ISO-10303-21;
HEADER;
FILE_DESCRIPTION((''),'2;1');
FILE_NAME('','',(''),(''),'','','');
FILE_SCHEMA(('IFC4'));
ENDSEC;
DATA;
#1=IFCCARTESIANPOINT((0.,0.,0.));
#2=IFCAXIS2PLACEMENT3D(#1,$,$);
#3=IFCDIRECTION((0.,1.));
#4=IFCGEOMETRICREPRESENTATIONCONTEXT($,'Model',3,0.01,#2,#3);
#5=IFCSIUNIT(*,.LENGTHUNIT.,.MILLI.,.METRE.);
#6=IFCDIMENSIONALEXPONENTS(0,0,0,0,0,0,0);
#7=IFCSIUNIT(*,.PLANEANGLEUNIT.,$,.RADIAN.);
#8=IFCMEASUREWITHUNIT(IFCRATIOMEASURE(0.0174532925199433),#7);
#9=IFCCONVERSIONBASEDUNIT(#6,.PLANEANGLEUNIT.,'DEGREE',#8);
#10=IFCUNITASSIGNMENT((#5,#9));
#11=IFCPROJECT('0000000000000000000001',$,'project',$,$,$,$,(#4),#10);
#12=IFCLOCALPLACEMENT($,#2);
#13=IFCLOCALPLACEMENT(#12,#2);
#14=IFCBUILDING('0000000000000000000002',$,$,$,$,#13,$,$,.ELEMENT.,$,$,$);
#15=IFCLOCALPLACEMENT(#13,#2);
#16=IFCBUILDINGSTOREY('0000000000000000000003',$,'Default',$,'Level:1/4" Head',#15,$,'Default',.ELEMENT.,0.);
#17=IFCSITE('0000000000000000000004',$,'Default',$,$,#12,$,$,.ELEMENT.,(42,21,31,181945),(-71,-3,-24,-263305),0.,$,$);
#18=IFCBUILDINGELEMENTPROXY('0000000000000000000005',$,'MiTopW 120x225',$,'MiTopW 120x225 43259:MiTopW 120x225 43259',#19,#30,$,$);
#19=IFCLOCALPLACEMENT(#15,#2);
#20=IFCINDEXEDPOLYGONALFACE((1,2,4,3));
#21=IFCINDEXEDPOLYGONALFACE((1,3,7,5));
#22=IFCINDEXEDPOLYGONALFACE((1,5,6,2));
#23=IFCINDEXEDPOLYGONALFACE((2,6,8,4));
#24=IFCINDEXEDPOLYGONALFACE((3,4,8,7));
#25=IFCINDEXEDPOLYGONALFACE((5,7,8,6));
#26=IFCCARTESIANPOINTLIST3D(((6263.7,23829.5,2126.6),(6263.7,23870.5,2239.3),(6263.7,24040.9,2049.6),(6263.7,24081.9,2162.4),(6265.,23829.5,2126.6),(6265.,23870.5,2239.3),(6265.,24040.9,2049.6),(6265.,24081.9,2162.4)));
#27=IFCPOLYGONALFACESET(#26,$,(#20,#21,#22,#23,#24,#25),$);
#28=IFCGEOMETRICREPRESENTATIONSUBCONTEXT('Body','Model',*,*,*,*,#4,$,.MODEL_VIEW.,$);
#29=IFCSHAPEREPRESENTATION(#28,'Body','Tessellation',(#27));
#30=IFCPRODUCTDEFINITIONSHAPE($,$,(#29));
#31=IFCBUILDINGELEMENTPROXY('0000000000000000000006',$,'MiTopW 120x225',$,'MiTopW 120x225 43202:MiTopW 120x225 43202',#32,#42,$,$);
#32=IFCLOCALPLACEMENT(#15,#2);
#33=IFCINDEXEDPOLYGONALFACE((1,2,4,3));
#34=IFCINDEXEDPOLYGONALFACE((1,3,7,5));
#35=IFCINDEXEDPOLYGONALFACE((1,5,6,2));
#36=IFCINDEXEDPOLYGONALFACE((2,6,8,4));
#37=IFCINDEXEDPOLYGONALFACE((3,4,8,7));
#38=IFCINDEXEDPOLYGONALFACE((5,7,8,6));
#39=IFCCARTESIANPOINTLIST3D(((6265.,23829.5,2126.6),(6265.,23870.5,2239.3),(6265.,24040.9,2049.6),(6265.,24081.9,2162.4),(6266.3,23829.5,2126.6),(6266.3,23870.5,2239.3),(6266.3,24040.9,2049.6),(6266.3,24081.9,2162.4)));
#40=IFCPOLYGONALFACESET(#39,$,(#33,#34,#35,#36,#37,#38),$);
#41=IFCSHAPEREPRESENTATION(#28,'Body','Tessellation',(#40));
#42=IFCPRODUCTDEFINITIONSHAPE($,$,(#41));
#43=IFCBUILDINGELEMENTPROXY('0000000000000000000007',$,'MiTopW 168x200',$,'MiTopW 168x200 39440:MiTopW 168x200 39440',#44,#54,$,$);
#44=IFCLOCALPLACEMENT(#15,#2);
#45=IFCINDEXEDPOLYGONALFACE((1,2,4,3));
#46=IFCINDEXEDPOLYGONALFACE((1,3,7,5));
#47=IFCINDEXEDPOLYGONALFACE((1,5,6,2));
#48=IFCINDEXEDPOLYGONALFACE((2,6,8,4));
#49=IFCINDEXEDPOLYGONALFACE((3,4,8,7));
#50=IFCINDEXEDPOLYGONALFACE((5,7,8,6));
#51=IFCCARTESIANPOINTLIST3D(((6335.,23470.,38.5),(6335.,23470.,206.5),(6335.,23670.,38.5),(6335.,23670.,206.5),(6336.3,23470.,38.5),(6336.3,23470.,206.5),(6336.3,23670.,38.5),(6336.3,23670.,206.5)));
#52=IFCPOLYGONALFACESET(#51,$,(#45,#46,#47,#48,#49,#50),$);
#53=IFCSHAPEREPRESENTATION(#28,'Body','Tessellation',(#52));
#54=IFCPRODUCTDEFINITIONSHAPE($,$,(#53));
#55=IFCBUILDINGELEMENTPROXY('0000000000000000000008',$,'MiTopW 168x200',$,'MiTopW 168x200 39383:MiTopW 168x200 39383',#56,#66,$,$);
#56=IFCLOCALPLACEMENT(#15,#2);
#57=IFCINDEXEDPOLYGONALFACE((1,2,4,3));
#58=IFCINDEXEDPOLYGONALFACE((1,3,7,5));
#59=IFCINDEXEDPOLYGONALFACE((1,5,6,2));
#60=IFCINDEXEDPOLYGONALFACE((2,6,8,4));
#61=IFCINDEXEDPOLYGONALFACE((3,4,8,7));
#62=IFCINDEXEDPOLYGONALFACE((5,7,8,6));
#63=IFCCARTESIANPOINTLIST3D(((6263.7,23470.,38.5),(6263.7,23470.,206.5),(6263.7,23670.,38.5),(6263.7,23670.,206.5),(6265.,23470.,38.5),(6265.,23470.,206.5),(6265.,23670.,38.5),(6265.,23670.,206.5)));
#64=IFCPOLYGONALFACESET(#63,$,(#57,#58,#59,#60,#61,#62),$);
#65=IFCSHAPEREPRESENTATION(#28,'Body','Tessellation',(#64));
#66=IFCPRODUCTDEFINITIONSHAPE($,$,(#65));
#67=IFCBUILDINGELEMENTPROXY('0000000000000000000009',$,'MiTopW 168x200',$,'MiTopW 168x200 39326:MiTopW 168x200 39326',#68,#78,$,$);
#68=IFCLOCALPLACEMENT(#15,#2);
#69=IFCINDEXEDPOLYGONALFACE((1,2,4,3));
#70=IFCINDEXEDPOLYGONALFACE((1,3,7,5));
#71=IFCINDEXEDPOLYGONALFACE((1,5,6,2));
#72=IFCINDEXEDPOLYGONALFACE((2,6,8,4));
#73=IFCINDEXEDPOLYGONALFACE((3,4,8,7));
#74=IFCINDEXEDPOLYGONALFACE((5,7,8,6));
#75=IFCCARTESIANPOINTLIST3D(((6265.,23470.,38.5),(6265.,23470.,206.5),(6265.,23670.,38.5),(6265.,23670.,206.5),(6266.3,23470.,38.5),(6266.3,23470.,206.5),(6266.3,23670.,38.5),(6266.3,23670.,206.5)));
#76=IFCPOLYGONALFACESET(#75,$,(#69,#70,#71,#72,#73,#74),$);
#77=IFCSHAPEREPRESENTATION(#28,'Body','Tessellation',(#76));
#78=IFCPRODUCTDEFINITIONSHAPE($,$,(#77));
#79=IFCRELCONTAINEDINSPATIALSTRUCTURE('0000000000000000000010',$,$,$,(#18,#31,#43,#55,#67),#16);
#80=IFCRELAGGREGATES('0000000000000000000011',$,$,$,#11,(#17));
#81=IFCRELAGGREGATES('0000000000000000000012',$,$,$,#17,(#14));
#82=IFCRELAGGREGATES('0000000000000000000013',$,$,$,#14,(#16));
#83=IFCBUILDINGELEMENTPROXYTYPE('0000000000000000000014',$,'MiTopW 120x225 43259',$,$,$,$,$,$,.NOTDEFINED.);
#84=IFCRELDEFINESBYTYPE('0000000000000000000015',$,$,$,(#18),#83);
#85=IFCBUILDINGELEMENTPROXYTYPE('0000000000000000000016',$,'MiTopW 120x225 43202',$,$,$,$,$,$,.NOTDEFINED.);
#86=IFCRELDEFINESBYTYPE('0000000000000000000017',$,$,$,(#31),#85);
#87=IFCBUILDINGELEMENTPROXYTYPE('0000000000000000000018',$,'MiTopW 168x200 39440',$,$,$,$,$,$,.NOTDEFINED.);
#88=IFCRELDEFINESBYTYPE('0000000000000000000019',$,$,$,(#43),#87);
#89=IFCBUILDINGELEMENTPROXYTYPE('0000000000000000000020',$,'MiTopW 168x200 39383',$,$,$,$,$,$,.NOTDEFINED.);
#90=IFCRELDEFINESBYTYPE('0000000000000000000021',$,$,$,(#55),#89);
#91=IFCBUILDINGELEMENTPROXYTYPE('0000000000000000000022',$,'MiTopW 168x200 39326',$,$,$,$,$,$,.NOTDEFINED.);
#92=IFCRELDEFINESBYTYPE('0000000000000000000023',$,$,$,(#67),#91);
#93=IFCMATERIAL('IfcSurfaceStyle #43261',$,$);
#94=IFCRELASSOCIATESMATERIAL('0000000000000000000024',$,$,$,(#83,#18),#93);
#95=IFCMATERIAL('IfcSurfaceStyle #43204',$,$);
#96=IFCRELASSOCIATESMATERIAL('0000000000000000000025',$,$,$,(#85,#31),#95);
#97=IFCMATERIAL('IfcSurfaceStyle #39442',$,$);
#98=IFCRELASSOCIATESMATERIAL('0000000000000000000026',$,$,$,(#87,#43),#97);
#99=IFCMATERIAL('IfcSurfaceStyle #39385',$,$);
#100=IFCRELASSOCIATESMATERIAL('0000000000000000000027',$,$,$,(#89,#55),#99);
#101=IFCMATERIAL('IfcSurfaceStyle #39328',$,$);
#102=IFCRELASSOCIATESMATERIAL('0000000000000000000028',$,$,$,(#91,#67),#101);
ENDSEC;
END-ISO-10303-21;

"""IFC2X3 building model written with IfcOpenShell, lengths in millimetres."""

from ifc_helpers import new_model, entity, si_unit, converted_unit, direction, frame, origin, origin_2d_with_axis, place, context, subcontext, project, spatial, polyline, rectangle, outline, extrude, source, transform, mapped, material, type_object, type_shapes, element, save


model = new_model("IFC2X3")

# Units and contexts
model_context = context("Model", 3, precision=0.01, world=origin(), true_north=direction((0.0, 1.0)))
body_context = subcontext(model_context, "Body", "Model", "MODEL_VIEW")
ifc_project = project(units=[si_unit("LENGTHUNIT", "METRE", prefix="MILLI"), converted_unit("PLANEANGLEUNIT", "DEGREE", entity("IfcRatioMeasure", 0.0174532925199433), si_unit("PLANEANGLEUNIT", "RADIAN"), dimensions=[0, 0, 0, 0, 0, 0, 0])], contexts=[model_context])

# Site, building, storey
site_placement = place(None, origin())
site = spatial("IfcSite", under=ifc_project, at=site_placement, Name="Default", CompositionType="ELEMENT", RefLatitude=(42, 21, 31, 181945), RefLongitude=(-71, -3, -24, -263305), RefElevation=0.0)
building_placement = place(site_placement, origin())
building = spatial("IfcBuilding", under=site, at=building_placement, CompositionType="ELEMENT")
storey_placement = place(building_placement, origin())
storey = spatial("IfcBuildingStorey", under=building, at=storey_placement, Name="Default", ObjectType="Level:1/4\" Head", LongName="Default", CompositionType="ELEMENT", Elevation=0.0)

# Building element proxies
ifc_material_1 = material(Name="IfcSurfaceStyle #43261")
building_element_proxy_type_1 = type_object("IfcBuildingElementProxyType", Name="MiTopW 120x225 43259", PredefinedType="NOTDEFINED", material=ifc_material_1)
shared_shape_1 = source(origin(), body_context, "Body", "SweptSolid", [
    extrude(outline(polyline([(-112.5, -60.0), (112.5, -60.0), (112.5, 60.0), (-112.5, 60.0), (-112.5, -60.0)])), frame((112.5, 60.0, 0.0), z_axis=(0.0, 0.0, 1.0), x_axis=(-1.0, 0.0, 0.0)), (0.0, 0.0, 1.0), 1.3),
])
type_shapes(building_element_proxy_type_1, [shared_shape_1])
proxy_1_placement = place(building_placement, frame((6265.0, 24040.9, 2049.6), z_axis=(-1.0, 0.0, 0.0), x_axis=(0.0, -0.939693, 0.34202)))
element("IfcBuildingElementProxy", 1, at=proxy_1_placement, inside=storey, type_object=building_element_proxy_type_1, material=ifc_material_1, Name="MiTopW 120x225", ObjectType="MiTopW 120x225 43259:MiTopW 120x225 43259", context=body_context, shape_type="MappedRepresentation", body=[
    mapped(shared_shape_1, transform((0.0, 0.0, 0.0), scale=1.0)),
])
ifc_material_2 = material(Name="IfcSurfaceStyle #43204")
building_element_proxy_type_2 = type_object("IfcBuildingElementProxyType", Name="MiTopW 120x225 43202", PredefinedType="NOTDEFINED", material=ifc_material_2)
shared_shape_2 = source(origin(), body_context, "Body", "SweptSolid", [
    extrude(outline(polyline([(-112.5, -60.0), (112.5, -60.0), (112.5, 60.0), (-112.5, 60.0), (-112.5, -60.0)])), frame((112.5, 60.0, 0.0), z_axis=(0.0, 0.0, 1.0), x_axis=(-1.0, 0.0, 0.0)), (0.0, 0.0, 1.0), 1.3),
])
type_shapes(building_element_proxy_type_2, [shared_shape_2])
proxy_2_placement = place(building_placement, frame((6266.3, 24040.9, 2049.6), z_axis=(-1.0, 0.0, 0.0), x_axis=(0.0, -0.939693, 0.34202)))
element("IfcBuildingElementProxy", 2, at=proxy_2_placement, inside=storey, type_object=building_element_proxy_type_2, material=ifc_material_2, Name="MiTopW 120x225", ObjectType="MiTopW 120x225 43202:MiTopW 120x225 43202", context=body_context, shape_type="MappedRepresentation", body=[
    mapped(shared_shape_2, transform((0.0, 0.0, 0.0), scale=1.0)),
])
ifc_material_3 = material(Name="IfcSurfaceStyle #39442")
building_element_proxy_type_3 = type_object("IfcBuildingElementProxyType", Name="MiTopW 168x200 39440", PredefinedType="NOTDEFINED", material=ifc_material_3)
shared_shape_3 = source(origin(), body_context, "Body", "SweptSolid", [
    extrude(rectangle(XDim=200.0, YDim=168.0, at=origin_2d_with_axis()), frame((100.0, 84.0, 0.0), z_axis=(0.0, 0.0, 1.0), x_axis=(-1.0, 0.0, 0.0)), (0.0, 0.0, 1.0), 1.3),
])
type_shapes(building_element_proxy_type_3, [shared_shape_3])
proxy_3_placement = place(building_placement, frame((6336.3, 23470.0, 206.5), z_axis=(-1.0, 0.0, 0.0), x_axis=(0.0, 1.0, 0.0)))
element("IfcBuildingElementProxy", 3, at=proxy_3_placement, inside=storey, type_object=building_element_proxy_type_3, material=ifc_material_3, Name="MiTopW 168x200", ObjectType="MiTopW 168x200 39440:MiTopW 168x200 39440", context=body_context, shape_type="MappedRepresentation", body=[
    mapped(shared_shape_3, transform((0.0, 0.0, 0.0), scale=1.0)),
])
ifc_material_4 = material(Name="IfcSurfaceStyle #39385")
building_element_proxy_type_4 = type_object("IfcBuildingElementProxyType", Name="MiTopW 168x200 39383", PredefinedType="NOTDEFINED", material=ifc_material_4)
shared_shape_4 = source(origin(), body_context, "Body", "SweptSolid", [
    extrude(rectangle(XDim=200.0, YDim=168.0, at=origin_2d_with_axis()), frame((100.0, 84.0, 0.0), z_axis=(0.0, 0.0, 1.0), x_axis=(-1.0, 0.0, 0.0)), (0.0, 0.0, 1.0), 1.3),
])
type_shapes(building_element_proxy_type_4, [shared_shape_4])
proxy_4_placement = place(building_placement, frame((6265.0, 23470.0, 206.5), z_axis=(-1.0, 0.0, 0.0), x_axis=(0.0, 1.0, 0.0)))
element("IfcBuildingElementProxy", 4, at=proxy_4_placement, inside=storey, type_object=building_element_proxy_type_4, material=ifc_material_4, Name="MiTopW 168x200", ObjectType="MiTopW 168x200 39383:MiTopW 168x200 39383", context=body_context, shape_type="MappedRepresentation", body=[
    mapped(shared_shape_4, transform((0.0, 0.0, 0.0), scale=1.0)),
])
ifc_material_5 = material(Name="IfcSurfaceStyle #39328")
building_element_proxy_type_5 = type_object("IfcBuildingElementProxyType", Name="MiTopW 168x200 39326", PredefinedType="NOTDEFINED", material=ifc_material_5)
shared_shape_5 = source(origin(), body_context, "Body", "SweptSolid", [
    extrude(rectangle(XDim=200.0, YDim=168.0, at=origin_2d_with_axis()), frame((100.0, 84.0, 0.0), z_axis=(0.0, 0.0, 1.0), x_axis=(-1.0, 0.0, 0.0)), (0.0, 0.0, 1.0), 1.3),
])
type_shapes(building_element_proxy_type_5, [shared_shape_5])
proxy_5_placement = place(building_placement, frame((6266.3, 23470.0, 206.5), z_axis=(-1.0, 0.0, 0.0), x_axis=(0.0, 1.0, 0.0)))
element("IfcBuildingElementProxy", 5, at=proxy_5_placement, inside=storey, type_object=building_element_proxy_type_5, material=ifc_material_5, Name="MiTopW 168x200", ObjectType="MiTopW 168x200 39326:MiTopW 168x200 39326", context=body_context, shape_type="MappedRepresentation", body=[
    mapped(shared_shape_5, transform((0.0, 0.0, 0.0), scale=1.0)),
])

save(model, "model.ifc")
